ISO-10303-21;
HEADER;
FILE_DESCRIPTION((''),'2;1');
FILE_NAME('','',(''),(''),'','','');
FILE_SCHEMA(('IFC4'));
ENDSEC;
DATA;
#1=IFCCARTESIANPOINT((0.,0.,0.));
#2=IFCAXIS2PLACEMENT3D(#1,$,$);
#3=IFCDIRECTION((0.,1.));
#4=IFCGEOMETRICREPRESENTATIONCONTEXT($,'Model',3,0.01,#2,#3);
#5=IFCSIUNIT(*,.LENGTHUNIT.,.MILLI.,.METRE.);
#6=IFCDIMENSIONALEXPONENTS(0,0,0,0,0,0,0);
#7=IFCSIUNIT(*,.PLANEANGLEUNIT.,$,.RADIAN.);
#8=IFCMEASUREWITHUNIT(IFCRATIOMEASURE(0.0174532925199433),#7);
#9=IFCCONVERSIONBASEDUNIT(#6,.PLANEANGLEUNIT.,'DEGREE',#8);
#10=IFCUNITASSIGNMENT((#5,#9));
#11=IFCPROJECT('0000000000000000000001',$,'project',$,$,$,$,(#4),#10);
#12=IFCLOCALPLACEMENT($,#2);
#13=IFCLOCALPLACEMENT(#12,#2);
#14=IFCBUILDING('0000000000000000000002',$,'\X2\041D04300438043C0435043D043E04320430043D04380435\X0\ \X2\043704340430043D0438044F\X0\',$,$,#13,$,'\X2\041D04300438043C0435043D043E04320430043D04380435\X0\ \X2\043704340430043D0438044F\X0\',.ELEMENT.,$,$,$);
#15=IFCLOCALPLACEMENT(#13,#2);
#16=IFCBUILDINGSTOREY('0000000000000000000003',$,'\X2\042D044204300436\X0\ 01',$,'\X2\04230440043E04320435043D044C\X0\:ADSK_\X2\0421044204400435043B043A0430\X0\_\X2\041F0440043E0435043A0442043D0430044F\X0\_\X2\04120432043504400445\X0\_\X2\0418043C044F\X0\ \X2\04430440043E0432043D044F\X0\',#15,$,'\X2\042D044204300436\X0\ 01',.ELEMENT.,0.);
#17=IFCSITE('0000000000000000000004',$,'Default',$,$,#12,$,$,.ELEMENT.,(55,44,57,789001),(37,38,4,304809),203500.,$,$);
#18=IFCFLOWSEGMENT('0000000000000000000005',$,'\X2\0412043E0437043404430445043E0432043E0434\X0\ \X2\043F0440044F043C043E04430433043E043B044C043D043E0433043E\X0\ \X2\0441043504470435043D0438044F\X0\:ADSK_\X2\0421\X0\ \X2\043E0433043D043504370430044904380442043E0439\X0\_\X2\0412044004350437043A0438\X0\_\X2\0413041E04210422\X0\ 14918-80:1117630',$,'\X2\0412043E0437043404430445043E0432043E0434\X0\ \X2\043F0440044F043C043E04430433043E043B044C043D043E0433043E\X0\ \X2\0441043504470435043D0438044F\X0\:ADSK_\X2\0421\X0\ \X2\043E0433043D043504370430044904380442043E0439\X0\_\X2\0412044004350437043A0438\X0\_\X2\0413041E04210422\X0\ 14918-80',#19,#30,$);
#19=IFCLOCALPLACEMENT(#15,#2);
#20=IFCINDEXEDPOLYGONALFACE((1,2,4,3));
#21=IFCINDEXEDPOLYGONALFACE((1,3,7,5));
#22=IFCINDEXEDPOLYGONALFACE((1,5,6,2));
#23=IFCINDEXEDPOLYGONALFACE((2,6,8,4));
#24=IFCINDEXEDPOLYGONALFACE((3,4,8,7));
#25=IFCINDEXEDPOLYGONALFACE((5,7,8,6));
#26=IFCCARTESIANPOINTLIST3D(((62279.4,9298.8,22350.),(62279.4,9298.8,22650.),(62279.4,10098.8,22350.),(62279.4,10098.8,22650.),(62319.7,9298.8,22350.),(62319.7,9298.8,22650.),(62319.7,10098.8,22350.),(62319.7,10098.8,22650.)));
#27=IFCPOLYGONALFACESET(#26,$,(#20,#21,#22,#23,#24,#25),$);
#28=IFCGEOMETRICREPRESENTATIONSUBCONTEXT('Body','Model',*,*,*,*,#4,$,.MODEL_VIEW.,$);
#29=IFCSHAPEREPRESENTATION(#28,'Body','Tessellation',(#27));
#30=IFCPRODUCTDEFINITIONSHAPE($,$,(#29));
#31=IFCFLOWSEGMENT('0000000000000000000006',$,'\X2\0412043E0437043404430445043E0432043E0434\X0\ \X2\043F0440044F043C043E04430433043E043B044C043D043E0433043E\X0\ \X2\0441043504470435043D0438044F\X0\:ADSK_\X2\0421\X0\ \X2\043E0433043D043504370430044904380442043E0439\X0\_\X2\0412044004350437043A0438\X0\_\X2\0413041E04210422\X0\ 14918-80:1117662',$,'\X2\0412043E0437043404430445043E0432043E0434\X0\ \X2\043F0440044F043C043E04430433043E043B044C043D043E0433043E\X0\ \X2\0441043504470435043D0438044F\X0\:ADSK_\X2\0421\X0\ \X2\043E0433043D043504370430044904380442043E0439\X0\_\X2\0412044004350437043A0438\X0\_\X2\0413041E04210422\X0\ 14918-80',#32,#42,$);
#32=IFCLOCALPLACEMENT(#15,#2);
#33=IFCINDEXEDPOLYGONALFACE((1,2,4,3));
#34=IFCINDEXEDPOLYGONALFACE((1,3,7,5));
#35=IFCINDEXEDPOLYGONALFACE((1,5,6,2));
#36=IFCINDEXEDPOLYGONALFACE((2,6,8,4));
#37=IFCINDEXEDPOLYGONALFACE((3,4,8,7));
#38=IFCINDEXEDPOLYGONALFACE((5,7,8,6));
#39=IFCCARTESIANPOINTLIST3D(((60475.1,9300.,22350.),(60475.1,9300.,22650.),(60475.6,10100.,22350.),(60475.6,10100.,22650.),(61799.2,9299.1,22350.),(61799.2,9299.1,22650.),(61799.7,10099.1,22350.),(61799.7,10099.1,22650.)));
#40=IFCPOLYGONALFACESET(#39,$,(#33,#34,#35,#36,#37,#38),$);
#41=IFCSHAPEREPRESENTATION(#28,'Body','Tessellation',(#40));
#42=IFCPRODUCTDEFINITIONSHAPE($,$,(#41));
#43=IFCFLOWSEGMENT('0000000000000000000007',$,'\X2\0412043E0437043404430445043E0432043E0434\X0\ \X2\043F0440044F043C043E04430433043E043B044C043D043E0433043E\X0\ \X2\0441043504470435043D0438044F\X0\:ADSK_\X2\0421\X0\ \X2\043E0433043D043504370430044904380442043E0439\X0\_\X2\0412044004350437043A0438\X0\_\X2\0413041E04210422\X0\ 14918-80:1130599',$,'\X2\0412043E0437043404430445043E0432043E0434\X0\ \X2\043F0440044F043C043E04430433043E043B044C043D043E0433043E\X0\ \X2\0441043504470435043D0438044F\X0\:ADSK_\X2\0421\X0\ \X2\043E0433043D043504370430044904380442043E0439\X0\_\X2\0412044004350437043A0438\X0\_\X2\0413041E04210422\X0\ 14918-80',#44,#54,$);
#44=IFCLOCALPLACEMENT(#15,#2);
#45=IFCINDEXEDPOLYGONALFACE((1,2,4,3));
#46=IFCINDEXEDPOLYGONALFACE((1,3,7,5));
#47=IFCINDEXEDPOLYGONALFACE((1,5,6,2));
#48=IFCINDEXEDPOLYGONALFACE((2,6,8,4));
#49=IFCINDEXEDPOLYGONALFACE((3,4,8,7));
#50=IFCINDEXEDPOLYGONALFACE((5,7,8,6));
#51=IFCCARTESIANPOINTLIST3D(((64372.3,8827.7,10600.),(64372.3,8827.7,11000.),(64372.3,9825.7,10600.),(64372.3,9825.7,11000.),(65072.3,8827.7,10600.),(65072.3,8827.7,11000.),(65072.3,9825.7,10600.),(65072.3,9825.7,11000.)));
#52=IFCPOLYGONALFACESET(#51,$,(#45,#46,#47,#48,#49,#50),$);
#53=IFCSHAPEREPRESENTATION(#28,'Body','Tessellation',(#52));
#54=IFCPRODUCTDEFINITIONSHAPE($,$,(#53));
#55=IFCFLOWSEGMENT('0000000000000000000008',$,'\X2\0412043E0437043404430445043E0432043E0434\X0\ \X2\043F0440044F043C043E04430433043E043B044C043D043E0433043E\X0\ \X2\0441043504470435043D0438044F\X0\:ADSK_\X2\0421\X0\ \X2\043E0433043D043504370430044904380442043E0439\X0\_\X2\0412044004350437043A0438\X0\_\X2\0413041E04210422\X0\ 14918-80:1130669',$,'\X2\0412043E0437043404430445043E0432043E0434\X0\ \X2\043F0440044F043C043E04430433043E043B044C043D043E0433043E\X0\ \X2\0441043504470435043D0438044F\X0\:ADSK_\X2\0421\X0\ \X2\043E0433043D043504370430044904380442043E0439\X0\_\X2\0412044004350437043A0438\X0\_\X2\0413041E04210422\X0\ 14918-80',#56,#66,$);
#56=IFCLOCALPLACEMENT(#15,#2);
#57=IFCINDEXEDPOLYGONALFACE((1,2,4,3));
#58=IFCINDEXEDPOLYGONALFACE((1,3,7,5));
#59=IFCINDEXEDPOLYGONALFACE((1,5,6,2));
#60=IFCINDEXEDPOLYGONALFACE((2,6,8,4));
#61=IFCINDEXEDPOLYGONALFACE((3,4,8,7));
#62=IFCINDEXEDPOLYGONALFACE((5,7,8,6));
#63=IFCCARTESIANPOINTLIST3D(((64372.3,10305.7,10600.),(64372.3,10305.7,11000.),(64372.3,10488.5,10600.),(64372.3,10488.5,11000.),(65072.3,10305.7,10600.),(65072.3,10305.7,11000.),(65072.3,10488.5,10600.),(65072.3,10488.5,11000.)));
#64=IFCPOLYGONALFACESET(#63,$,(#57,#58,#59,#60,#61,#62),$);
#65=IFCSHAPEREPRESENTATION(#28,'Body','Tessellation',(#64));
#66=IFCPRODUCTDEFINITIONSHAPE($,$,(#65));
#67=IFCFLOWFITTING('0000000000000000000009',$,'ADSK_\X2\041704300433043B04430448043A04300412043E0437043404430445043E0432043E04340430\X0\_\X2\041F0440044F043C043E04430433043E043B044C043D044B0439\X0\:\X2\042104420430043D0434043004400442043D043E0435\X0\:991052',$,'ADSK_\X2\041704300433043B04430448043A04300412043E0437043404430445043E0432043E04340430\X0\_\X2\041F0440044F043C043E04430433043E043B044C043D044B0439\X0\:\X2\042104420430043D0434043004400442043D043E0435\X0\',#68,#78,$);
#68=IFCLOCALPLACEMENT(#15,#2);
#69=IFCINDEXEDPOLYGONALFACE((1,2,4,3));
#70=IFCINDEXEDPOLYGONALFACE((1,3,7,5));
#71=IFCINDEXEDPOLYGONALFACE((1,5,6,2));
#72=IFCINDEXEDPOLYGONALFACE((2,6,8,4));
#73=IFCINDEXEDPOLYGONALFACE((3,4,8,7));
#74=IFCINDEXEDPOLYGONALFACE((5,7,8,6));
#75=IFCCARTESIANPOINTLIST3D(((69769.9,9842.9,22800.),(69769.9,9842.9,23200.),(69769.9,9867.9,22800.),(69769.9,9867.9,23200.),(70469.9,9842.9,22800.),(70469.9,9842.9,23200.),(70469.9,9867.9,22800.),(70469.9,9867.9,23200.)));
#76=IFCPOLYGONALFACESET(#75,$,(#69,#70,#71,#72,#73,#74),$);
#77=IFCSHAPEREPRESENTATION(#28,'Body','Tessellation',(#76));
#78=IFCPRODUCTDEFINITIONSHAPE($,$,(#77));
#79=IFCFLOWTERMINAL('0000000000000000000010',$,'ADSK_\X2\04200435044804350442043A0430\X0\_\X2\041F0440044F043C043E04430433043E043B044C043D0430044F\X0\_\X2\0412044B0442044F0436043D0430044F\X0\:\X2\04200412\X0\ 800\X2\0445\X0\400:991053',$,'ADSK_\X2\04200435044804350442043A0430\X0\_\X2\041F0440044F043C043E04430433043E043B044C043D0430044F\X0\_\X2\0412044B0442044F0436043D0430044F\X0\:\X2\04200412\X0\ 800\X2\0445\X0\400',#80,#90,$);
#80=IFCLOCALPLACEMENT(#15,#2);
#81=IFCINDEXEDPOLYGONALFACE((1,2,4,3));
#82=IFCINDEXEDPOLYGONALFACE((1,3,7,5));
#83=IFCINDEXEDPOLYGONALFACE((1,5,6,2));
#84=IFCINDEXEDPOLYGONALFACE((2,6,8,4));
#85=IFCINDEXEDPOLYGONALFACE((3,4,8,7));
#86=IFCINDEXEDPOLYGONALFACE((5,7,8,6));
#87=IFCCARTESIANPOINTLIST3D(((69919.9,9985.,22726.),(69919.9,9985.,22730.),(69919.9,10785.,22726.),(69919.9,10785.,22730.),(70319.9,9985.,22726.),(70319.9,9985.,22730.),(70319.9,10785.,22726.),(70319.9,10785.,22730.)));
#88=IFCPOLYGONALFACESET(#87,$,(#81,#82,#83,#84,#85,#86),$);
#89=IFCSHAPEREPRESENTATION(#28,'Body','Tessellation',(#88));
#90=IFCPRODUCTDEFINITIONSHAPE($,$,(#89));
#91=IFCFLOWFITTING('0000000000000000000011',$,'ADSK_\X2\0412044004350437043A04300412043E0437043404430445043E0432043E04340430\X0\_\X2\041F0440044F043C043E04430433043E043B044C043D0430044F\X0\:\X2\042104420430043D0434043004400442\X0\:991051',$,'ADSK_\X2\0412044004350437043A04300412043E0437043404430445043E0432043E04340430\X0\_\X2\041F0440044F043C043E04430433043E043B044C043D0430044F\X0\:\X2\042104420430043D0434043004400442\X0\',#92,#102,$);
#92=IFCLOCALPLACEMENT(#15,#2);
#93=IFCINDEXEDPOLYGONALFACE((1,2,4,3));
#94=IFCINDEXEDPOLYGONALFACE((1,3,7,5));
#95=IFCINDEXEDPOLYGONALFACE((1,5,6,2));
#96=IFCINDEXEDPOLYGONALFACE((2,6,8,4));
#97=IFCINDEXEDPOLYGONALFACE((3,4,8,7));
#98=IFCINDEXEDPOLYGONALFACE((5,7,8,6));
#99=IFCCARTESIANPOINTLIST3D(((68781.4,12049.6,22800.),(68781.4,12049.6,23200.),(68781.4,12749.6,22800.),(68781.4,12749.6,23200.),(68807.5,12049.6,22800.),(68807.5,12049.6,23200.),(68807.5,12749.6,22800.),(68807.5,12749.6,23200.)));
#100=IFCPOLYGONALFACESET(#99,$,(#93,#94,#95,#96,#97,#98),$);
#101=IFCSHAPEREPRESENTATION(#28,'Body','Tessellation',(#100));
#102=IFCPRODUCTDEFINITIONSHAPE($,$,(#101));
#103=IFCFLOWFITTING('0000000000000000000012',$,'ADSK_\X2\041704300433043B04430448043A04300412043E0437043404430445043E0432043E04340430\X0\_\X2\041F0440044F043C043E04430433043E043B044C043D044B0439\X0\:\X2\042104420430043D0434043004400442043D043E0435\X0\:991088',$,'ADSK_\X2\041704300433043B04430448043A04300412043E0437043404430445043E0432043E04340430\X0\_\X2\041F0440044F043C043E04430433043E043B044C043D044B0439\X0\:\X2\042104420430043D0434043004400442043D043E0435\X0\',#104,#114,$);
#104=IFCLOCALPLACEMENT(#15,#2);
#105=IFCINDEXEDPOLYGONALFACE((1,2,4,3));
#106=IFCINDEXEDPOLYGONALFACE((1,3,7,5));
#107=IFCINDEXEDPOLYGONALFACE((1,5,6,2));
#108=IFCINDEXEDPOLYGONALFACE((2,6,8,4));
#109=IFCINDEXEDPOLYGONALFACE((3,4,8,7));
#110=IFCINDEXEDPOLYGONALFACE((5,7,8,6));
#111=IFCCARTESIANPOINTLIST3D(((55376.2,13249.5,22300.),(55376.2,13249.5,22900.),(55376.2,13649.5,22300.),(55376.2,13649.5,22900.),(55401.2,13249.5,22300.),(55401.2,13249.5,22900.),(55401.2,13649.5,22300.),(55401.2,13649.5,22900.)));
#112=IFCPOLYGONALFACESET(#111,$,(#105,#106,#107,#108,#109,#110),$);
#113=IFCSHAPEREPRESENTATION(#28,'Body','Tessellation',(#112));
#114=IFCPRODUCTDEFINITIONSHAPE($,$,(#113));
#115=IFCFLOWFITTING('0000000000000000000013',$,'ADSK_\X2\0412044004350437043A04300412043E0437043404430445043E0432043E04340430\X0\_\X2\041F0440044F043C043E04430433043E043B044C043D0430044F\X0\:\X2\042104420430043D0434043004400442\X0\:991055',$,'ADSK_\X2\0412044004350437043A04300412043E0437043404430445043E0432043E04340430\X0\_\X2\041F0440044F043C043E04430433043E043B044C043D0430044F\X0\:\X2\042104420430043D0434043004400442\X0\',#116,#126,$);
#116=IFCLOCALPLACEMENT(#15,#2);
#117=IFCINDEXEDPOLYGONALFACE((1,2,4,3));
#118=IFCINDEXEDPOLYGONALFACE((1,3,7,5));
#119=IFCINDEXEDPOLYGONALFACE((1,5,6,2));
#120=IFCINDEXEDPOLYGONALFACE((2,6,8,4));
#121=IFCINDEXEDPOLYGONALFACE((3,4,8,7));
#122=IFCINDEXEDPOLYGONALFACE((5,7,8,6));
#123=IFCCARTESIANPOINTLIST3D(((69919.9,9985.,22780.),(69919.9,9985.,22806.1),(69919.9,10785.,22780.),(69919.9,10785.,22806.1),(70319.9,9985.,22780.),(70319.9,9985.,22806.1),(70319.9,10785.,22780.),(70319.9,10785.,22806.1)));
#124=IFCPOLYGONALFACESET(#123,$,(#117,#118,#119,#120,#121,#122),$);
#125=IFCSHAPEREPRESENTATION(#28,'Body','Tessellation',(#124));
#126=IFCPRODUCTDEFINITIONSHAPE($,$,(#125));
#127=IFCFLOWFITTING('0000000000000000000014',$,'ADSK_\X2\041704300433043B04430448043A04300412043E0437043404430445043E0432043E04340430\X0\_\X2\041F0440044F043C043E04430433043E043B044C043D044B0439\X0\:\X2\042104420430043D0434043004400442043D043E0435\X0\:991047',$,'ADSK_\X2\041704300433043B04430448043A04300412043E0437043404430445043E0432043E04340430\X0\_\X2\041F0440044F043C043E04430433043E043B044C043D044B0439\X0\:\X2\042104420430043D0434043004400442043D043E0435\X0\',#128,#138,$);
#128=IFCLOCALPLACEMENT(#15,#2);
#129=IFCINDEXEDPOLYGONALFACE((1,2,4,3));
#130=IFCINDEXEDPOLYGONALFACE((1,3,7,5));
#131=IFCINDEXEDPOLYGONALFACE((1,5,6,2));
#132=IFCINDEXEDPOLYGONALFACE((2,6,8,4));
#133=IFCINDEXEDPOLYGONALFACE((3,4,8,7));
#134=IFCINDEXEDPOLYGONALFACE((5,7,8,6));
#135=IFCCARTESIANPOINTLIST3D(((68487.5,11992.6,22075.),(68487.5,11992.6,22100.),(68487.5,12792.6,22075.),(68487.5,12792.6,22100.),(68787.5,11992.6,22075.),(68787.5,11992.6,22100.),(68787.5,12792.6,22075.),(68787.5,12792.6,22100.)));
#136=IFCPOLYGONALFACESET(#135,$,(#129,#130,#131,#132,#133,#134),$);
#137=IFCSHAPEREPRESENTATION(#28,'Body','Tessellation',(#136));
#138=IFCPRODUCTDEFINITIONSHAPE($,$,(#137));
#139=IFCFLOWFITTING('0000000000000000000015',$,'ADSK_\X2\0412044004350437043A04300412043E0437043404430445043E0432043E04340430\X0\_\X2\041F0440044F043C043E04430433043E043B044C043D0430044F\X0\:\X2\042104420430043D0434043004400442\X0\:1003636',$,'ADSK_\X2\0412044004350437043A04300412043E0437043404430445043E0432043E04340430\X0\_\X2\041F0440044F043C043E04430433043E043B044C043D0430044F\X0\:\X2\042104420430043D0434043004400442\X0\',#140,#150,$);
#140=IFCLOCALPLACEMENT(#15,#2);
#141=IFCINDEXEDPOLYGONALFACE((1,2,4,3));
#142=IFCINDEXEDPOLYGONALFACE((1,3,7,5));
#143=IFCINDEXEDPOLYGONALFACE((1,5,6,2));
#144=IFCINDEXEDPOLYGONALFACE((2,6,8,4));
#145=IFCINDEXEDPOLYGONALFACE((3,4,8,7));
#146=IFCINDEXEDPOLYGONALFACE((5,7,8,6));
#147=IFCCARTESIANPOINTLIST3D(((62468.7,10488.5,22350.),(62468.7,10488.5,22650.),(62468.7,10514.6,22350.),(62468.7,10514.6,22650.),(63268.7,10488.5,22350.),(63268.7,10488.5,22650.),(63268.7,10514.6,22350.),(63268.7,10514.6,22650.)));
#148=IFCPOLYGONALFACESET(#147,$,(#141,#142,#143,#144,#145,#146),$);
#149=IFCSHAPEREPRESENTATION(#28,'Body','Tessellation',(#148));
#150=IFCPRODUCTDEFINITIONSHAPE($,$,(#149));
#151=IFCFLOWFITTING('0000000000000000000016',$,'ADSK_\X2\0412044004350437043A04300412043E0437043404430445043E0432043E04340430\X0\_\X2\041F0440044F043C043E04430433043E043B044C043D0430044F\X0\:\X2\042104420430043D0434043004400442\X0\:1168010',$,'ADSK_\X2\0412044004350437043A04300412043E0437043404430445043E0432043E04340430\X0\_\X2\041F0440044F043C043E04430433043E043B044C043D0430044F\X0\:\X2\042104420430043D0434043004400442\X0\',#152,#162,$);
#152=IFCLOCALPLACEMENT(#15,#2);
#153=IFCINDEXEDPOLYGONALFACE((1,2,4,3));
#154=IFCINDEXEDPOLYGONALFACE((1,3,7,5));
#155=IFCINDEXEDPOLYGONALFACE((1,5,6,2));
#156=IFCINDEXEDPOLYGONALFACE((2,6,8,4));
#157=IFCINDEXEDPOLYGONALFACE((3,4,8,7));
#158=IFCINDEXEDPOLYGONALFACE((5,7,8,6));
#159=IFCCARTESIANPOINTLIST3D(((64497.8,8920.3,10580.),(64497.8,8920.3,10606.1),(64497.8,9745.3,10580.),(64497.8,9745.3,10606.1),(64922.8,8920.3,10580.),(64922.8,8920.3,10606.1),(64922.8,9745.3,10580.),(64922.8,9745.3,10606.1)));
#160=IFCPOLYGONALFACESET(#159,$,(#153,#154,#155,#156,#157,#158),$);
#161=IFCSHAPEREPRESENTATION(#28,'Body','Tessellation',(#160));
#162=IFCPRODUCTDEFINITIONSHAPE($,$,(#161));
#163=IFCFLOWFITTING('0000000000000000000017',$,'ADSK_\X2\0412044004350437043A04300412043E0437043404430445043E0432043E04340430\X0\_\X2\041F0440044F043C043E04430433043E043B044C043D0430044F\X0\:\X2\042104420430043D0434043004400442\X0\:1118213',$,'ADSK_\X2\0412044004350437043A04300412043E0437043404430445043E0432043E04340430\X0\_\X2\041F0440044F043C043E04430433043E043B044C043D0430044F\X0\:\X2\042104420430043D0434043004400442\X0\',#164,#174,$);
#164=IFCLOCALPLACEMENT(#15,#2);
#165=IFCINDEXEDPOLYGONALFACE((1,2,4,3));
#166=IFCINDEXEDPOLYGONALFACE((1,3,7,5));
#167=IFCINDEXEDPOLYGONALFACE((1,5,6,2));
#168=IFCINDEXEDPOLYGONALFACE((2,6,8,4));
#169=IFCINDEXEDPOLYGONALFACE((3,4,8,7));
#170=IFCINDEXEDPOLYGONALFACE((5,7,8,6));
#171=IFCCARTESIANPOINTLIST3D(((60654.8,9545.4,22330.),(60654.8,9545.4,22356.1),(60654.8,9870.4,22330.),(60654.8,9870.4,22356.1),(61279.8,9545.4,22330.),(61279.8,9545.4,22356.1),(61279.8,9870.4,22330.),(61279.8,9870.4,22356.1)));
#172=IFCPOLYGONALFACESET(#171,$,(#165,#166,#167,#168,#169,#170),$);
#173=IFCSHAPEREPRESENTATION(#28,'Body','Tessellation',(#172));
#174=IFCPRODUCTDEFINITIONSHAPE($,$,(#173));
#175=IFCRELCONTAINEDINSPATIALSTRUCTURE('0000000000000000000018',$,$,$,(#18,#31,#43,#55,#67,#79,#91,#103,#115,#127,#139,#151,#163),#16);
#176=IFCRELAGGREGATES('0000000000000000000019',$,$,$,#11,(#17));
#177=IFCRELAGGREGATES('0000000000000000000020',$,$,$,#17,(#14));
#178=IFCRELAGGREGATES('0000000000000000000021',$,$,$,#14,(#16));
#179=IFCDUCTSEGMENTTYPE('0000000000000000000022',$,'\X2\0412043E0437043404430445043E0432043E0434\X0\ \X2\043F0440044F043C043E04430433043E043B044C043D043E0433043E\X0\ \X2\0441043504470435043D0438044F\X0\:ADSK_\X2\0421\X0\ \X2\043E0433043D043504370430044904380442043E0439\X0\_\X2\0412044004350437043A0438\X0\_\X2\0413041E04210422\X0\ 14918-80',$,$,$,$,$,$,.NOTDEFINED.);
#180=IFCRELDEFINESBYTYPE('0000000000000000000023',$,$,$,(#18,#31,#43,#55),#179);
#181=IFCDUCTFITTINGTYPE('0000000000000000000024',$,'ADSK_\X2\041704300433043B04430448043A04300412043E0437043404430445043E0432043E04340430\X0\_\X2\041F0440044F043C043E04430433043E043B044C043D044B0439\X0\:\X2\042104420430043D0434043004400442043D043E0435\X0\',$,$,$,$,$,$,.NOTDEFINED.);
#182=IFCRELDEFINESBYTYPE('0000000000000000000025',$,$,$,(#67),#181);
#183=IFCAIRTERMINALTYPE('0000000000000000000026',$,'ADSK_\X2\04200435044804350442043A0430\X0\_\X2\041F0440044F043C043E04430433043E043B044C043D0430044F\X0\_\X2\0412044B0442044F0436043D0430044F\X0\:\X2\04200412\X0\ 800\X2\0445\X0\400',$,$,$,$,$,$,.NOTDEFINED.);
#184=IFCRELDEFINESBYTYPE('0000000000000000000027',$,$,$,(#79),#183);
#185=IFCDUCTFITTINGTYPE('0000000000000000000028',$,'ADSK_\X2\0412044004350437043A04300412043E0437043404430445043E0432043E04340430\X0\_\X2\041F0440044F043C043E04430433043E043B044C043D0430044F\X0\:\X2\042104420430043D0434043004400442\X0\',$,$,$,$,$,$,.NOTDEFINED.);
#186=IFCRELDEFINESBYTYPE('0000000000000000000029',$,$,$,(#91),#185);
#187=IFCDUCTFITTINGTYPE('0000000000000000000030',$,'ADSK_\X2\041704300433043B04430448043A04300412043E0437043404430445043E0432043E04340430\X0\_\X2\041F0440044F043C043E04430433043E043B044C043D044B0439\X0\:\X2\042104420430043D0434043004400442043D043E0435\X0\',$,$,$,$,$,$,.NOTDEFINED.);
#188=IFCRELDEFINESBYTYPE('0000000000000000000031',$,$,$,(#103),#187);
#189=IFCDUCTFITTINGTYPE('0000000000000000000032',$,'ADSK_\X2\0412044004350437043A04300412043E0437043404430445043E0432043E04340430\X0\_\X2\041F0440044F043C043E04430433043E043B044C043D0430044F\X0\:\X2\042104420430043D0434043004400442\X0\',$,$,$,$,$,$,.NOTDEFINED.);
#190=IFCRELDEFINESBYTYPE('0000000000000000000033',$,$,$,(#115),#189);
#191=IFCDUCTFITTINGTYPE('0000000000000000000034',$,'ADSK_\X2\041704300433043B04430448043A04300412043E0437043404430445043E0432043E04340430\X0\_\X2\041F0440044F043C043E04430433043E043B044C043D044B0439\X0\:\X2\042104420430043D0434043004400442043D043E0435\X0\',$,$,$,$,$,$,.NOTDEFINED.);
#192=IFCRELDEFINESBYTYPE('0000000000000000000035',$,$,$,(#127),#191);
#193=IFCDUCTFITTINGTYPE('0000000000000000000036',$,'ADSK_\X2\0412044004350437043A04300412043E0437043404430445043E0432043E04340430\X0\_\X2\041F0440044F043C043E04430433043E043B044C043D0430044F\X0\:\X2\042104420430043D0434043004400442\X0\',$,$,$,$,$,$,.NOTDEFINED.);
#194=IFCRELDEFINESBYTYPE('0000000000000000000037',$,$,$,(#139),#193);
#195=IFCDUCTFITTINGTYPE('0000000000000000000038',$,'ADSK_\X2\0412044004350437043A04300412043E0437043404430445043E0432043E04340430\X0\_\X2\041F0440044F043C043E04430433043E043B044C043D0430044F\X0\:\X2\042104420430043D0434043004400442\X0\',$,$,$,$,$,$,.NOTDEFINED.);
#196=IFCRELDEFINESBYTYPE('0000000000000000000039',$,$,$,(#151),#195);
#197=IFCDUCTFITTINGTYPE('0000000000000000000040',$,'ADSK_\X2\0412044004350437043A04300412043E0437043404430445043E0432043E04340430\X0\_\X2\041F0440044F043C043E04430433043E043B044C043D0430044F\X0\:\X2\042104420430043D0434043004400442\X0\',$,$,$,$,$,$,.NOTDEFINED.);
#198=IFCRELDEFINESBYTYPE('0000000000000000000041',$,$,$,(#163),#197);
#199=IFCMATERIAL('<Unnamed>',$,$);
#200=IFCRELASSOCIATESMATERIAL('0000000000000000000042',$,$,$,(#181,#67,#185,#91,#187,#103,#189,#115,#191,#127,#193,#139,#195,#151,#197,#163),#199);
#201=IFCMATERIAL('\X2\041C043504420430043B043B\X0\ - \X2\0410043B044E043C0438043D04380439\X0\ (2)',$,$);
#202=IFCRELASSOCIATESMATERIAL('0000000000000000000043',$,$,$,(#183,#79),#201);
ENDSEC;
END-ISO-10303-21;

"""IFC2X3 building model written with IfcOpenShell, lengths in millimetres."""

from ifc_helpers import new_model, entity, si_unit, converted_unit, direction, frame, frame_2d, origin, origin_2d_with_axis, place, context, subcontext, project, spatial, rectangle, extrude, source, transform, mapped, material, type_object, type_shapes, element, save


model = new_model("IFC2X3")

# Units and contexts
model_context = context("Model", 3, precision=0.01, world=origin(), true_north=direction((0.0, 1.0)))
body_context = subcontext(model_context, "Body", "Model", "MODEL_VIEW")
ifc_project = project(units=[si_unit("LENGTHUNIT", "METRE", prefix="MILLI"), converted_unit("PLANEANGLEUNIT", "DEGREE", entity("IfcRatioMeasure", 0.0174532925199433), si_unit("PLANEANGLEUNIT", "RADIAN"), dimensions=[0, 0, 0, 0, 0, 0, 0])], contexts=[model_context])

# Site, building, storey
site_placement = place(None, frame((0.0, 0.0, 0.0)))
site = spatial("IfcSite", under=ifc_project, at=site_placement, Name="Default", CompositionType="ELEMENT", RefLatitude=(55, 44, 57, 789001), RefLongitude=(37, 38, 4, 304809), RefElevation=203500.0)
building_placement = place(site_placement, origin())
building = spatial("IfcBuilding", under=site, at=building_placement, Name="Наименование здания", LongName="Наименование здания", CompositionType="ELEMENT")
storey_placement = place(building_placement, origin())
storey = spatial("IfcBuildingStorey", under=building, at=storey_placement, Name="Этаж 01", ObjectType="Уровень:ADSK_Стрелка_Проектная_Вверх_Имя уровня", LongName="Этаж 01", CompositionType="ELEMENT", Elevation=0.0)

# Flow segments
duct_segment_type = type_object("IfcDuctSegmentType", Name="Воздуховод прямоугольного сечения:ADSK_С огнезащитой_Врезки_ГОСТ 14918-80", PredefinedType="NOTDEFINED")
flow_segment_1_placement = place(storey_placement, frame((62279.4, 9298.8, 22350.0)))
element("IfcFlowSegment", 1, at=flow_segment_1_placement, inside=storey, type_object=duct_segment_type, Name="Воздуховод прямоугольного сечения:ADSK_С огнезащитой_Врезки_ГОСТ 14918-80:1117630", ObjectType="Воздуховод прямоугольного сечения:ADSK_С огнезащитой_Врезки_ГОСТ 14918-80", context=body_context, shape_type="SweptSolid", body=[
    extrude(rectangle(XDim=40.3, YDim=800.0, at=frame_2d((0.0, 0.0), x_axis=(1.0, 0.0))), frame((20.1, 400.0, 0.0), z_axis=(0.0, 0.0, 1.0), x_axis=(-1.0, 0.0, 0.0)), (0.0, 0.0, 1.0), 300.0),
])
flow_segment_2_placement = place(storey_placement, frame((60475.1, 9299.1, 22350.0)))
element("IfcFlowSegment", 2, at=flow_segment_2_placement, inside=storey, type_object=duct_segment_type, Name="Воздуховод прямоугольного сечения:ADSK_С огнезащитой_Врезки_ГОСТ 14918-80:1117662", ObjectType="Воздуховод прямоугольного сечения:ADSK_С огнезащитой_Врезки_ГОСТ 14918-80", context=body_context, shape_type="SweptSolid", body=[
    extrude(rectangle(XDim=1324.1, YDim=800.0, at=frame_2d((0.0, 0.0), x_axis=(1.0, 0.0))), frame((662.3, 400.4, 0.0), z_axis=(0.0, 0.0, 1.0), x_axis=(-1.0, 0.000623, 0.0)), (0.0, 0.0, 1.0), 300.0),
])
flow_segment_3_placement = place(storey_placement, frame((64372.3, 8827.7, 10600.0)))
element("IfcFlowSegment", 3, at=flow_segment_3_placement, inside=storey, type_object=duct_segment_type, Name="Воздуховод прямоугольного сечения:ADSK_С огнезащитой_Врезки_ГОСТ 14918-80:1130599", ObjectType="Воздуховод прямоугольного сечения:ADSK_С огнезащитой_Врезки_ГОСТ 14918-80", context=body_context, shape_type="SweptSolid", body=[
    extrude(rectangle(XDim=998.0, YDim=700.0, at=frame_2d((0.0, 0.0), x_axis=(1.0, 0.0))), frame((350.0, 499.0, 0.0), z_axis=(0.0, 0.0, 1.0), x_axis=(0.0, -1.0, 0.0)), (0.0, 0.0, 1.0), 400.0),
])
flow_segment_4_placement = place(storey_placement, frame((64372.3, 10305.7, 10600.0)))
element("IfcFlowSegment", 4, at=flow_segment_4_placement, inside=storey, type_object=duct_segment_type, Name="Воздуховод прямоугольного сечения:ADSK_С огнезащитой_Врезки_ГОСТ 14918-80:1130669", ObjectType="Воздуховод прямоугольного сечения:ADSK_С огнезащитой_Врезки_ГОСТ 14918-80", context=body_context, shape_type="SweptSolid", body=[
    extrude(rectangle(XDim=182.8, YDim=700.0, at=frame_2d((0.0, 0.0), x_axis=(1.0, 0.0))), frame((350.0, 91.4, 0.0), z_axis=(0.0, 0.0, 1.0), x_axis=(0.0, 1.0, 0.0)), (0.0, 0.0, 1.0), 400.0),
])

# Flow fitting
ifc_material_1 = material(Name="<Unnamed>")
duct_fitting_type_1 = type_object("IfcDuctFittingType", Name="ADSK_ЗаглушкаВоздуховода_Прямоугольный:Стандартное", PredefinedType="NOTDEFINED", material=ifc_material_1)
shared_shape_1 = source(origin(), body_context, "Body", "SweptSolid", [
    extrude(rectangle(XDim=25.0, YDim=700.0, at=frame_2d((0.0, 0.0), x_axis=(1.0, 0.0))), frame((12.5, 0.0, -200.0)), (0.0, 0.0, 1.0), 400.0),
])
type_shapes(duct_fitting_type_1, [shared_shape_1])
flow_fitting_1_placement = place(storey_placement, frame((70119.9, 9867.9, 23000.0), z_axis=(0.0, 0.0, 1.0), x_axis=(0.0, -1.0, 0.0)))
element("IfcFlowFitting", 5, at=flow_fitting_1_placement, inside=storey, type_object=duct_fitting_type_1, material=ifc_material_1, Name="ADSK_ЗаглушкаВоздуховода_Прямоугольный:Стандартное:991052", ObjectType="ADSK_ЗаглушкаВоздуховода_Прямоугольный:Стандартное", context=body_context, shape_type="MappedRepresentation", body=[
    mapped(shared_shape_1, transform((0.0, 0.0, 0.0), scale=1.0)),
])

# Flow terminal
ifc_material_2 = material(Name="Металл - Алюминий (2)")
air_terminal_type = type_object("IfcAirTerminalType", Name="ADSK_Решетка_Прямоугольная_Вытяжная:РВ 800х400", PredefinedType="NOTDEFINED", material=ifc_material_2)
shared_shape_2 = source(origin(), body_context, "Body", "SweptSolid", [
    extrude(rectangle(XDim=4.0, YDim=800.0, at=origin_2d_with_axis()), frame((0.0, -2.0, -200.0), z_axis=(0.0, 0.0, 1.0), x_axis=(0.0, 1.0, 0.0)), (0.0, 0.0, 1.0), 400.0),
])
type_shapes(air_terminal_type, [shared_shape_2])
flow_terminal_placement = place(storey_placement, frame((70119.9, 10385.0, 22730.0), z_axis=(1.0, 0.0, 0.0), x_axis=(0.0, 1.0, 0.0)))
element("IfcFlowTerminal", 6, at=flow_terminal_placement, inside=storey, type_object=air_terminal_type, material=ifc_material_2, Name="ADSK_Решетка_Прямоугольная_Вытяжная:РВ 800х400:991053", ObjectType="ADSK_Решетка_Прямоугольная_Вытяжная:РВ 800х400", context=body_context, shape_type="MappedRepresentation", body=[
    mapped(shared_shape_2, transform((0.0, 0.0, 0.0), scale=1.0)),
])

# Flow fittings
duct_fitting_type_2 = type_object("IfcDuctFittingType", Name="ADSK_ВрезкаВоздуховода_Прямоугольная:Стандарт", PredefinedType="NOTDEFINED", material=ifc_material_1)
shared_shape_3 = source(origin(), body_context, "Body", "SweptSolid", [
    extrude(rectangle(XDim=26.1, YDim=400.0, at=frame_2d((0.0, 0.0), x_axis=(1.0, 0.0))), frame((7.0, 0.0, -350.0)), (0.0, 0.0, 1.0), 700.0),
])
type_shapes(duct_fitting_type_2, [shared_shape_3])
flow_fitting_2_placement = place(storey_placement, frame((68787.5, 12399.6, 23000.0), z_axis=(0.0, -1.0, 0.0), x_axis=(1.0, 0.0, 0.0)))
element("IfcFlowFitting", 7, at=flow_fitting_2_placement, inside=storey, type_object=duct_fitting_type_2, material=ifc_material_1, Name="ADSK_ВрезкаВоздуховода_Прямоугольная:Стандарт:991051", ObjectType="ADSK_ВрезкаВоздуховода_Прямоугольная:Стандарт", context=body_context, shape_type="MappedRepresentation", body=[
    mapped(shared_shape_3, transform((0.0, 0.0, 0.0), scale=1.0)),
])
duct_fitting_type_3 = type_object("IfcDuctFittingType", Name="ADSK_ЗаглушкаВоздуховода_Прямоугольный:Стандартное", PredefinedType="NOTDEFINED", material=ifc_material_1)
shared_shape_4 = source(origin(), body_context, "Body", "SweptSolid", [
    extrude(rectangle(XDim=25.0, YDim=400.0, at=frame_2d((0.0, 0.0), x_axis=(1.0, 0.0))), frame((12.5, 0.0, -300.0)), (0.0, 0.0, 1.0), 600.0),
])
type_shapes(duct_fitting_type_3, [shared_shape_4])
flow_fitting_3_placement = place(storey_placement, frame((55376.2, 13449.5, 22600.0)))
element("IfcFlowFitting", 8, at=flow_fitting_3_placement, inside=storey, type_object=duct_fitting_type_3, material=ifc_material_1, Name="ADSK_ЗаглушкаВоздуховода_Прямоугольный:Стандартное:991088", ObjectType="ADSK_ЗаглушкаВоздуховода_Прямоугольный:Стандартное", context=body_context, shape_type="MappedRepresentation", body=[
    mapped(shared_shape_4, transform((0.0, 0.0, 0.0), scale=1.0)),
])
duct_fitting_type_4 = type_object("IfcDuctFittingType", Name="ADSK_ВрезкаВоздуховода_Прямоугольная:Стандарт", PredefinedType="NOTDEFINED", material=ifc_material_1)
shared_shape_5 = source(origin(), body_context, "Body", "SweptSolid", [
    extrude(rectangle(XDim=400.0, YDim=26.1, at=origin_2d_with_axis()), frame((7.0, 0.0, -400.0), z_axis=(0.0, 0.0, 1.0), x_axis=(0.0, -1.0, 0.0)), (0.0, 0.0, 1.0), 800.0),
])
type_shapes(duct_fitting_type_4, [shared_shape_5])
flow_fitting_4_placement = place(storey_placement, frame((70119.9, 10385.0, 22800.0), z_axis=(0.0, -1.0, 0.0), x_axis=(0.0, 0.0, -1.0)))
element("IfcFlowFitting", 9, at=flow_fitting_4_placement, inside=storey, type_object=duct_fitting_type_4, material=ifc_material_1, Name="ADSK_ВрезкаВоздуховода_Прямоугольная:Стандарт:991055", ObjectType="ADSK_ВрезкаВоздуховода_Прямоугольная:Стандарт", context=body_context, shape_type="MappedRepresentation", body=[
    mapped(shared_shape_5, transform((0.0, 0.0, 0.0), scale=1.0)),
])
duct_fitting_type_5 = type_object("IfcDuctFittingType", Name="ADSK_ЗаглушкаВоздуховода_Прямоугольный:Стандартное", PredefinedType="NOTDEFINED", material=ifc_material_1)
shared_shape_6 = source(origin(), body_context, "Body", "SweptSolid", [
    extrude(rectangle(XDim=25.0, YDim=300.0, at=frame_2d((0.0, 0.0), x_axis=(1.0, 0.0))), frame((12.5, 0.0, -400.0)), (0.0, 0.0, 1.0), 800.0),
])
type_shapes(duct_fitting_type_5, [shared_shape_6])
flow_fitting_5_placement = place(storey_placement, frame((68637.5, 12392.6, 22100.0), z_axis=(0.0, -1.0, 0.0), x_axis=(0.0, 0.0, -1.0)))
element("IfcFlowFitting", 10, at=flow_fitting_5_placement, inside=storey, type_object=duct_fitting_type_5, material=ifc_material_1, Name="ADSK_ЗаглушкаВоздуховода_Прямоугольный:Стандартное:991047", ObjectType="ADSK_ЗаглушкаВоздуховода_Прямоугольный:Стандартное", context=body_context, shape_type="MappedRepresentation", body=[
    mapped(shared_shape_6, transform((0.0, 0.0, 0.0), scale=1.0)),
])
duct_fitting_type_6 = type_object("IfcDuctFittingType", Name="ADSK_ВрезкаВоздуховода_Прямоугольная:Стандарт", PredefinedType="NOTDEFINED", material=ifc_material_1)
shared_shape_7 = source(origin(), body_context, "Body", "SweptSolid", [
    extrude(rectangle(XDim=26.1, YDim=300.0, at=frame_2d((0.0, 0.0), x_axis=(1.0, 0.0))), frame((7.0, 0.0, -400.0)), (0.0, 0.0, 1.0), 800.0),
])
type_shapes(duct_fitting_type_6, [shared_shape_7])
flow_fitting_6_placement = place(storey_placement, frame((62868.7, 10508.5, 22500.0), z_axis=(-1.0, 0.0, 0.0), x_axis=(0.0, -1.0, 0.0)))
element("IfcFlowFitting", 11, at=flow_fitting_6_placement, inside=storey, type_object=duct_fitting_type_6, material=ifc_material_1, Name="ADSK_ВрезкаВоздуховода_Прямоугольная:Стандарт:1003636", ObjectType="ADSK_ВрезкаВоздуховода_Прямоугольная:Стандарт", context=body_context, shape_type="MappedRepresentation", body=[
    mapped(shared_shape_7, transform((0.0, 0.0, 0.0), scale=1.0)),
])
duct_fitting_type_7 = type_object("IfcDuctFittingType", Name="ADSK_ВрезкаВоздуховода_Прямоугольная:Стандарт", PredefinedType="NOTDEFINED", material=ifc_material_1)
shared_shape_8 = source(origin(), body_context, "Body", "SweptSolid", [
    extrude(rectangle(XDim=425.0, YDim=26.1, at=origin_2d_with_axis()), frame((7.0, 0.0, -412.5), z_axis=(0.0, 0.0, 1.0), x_axis=(0.0, -1.0, 0.0)), (0.0, 0.0, 1.0), 825.0),
])
type_shapes(duct_fitting_type_7, [shared_shape_8])
flow_fitting_7_placement = place(storey_placement, frame((64710.3, 9332.8, 10600.0), z_axis=(0.0, 1.0, 0.0), x_axis=(0.0, 0.0, -1.0)))
element("IfcFlowFitting", 12, at=flow_fitting_7_placement, inside=storey, type_object=duct_fitting_type_7, material=ifc_material_1, Name="ADSK_ВрезкаВоздуховода_Прямоугольная:Стандарт:1168010", ObjectType="ADSK_ВрезкаВоздуховода_Прямоугольная:Стандарт", context=body_context, shape_type="MappedRepresentation", body=[
    mapped(shared_shape_8, transform((0.0, 0.0, 0.0), scale=1.0)),
])
duct_fitting_type_8 = type_object("IfcDuctFittingType", Name="ADSK_ВрезкаВоздуховода_Прямоугольная:Стандарт", PredefinedType="NOTDEFINED", material=ifc_material_1)
shared_shape_9 = source(origin(), body_context, "Body", "SweptSolid", [
    extrude(rectangle(XDim=26.1, YDim=625.0, at=frame_2d((0.0, 0.0), x_axis=(1.0, 0.0))), frame((7.0, 0.0, -162.5)), (0.0, 0.0, 1.0), 325.0),
])
type_shapes(duct_fitting_type_8, [shared_shape_9])
flow_fitting_8_placement = place(storey_placement, frame((60967.3, 9707.9, 22350.0), z_axis=(0.0, -1.0, 0.0), x_axis=(0.0, 0.0, -1.0)))
element("IfcFlowFitting", 13, at=flow_fitting_8_placement, inside=storey, type_object=duct_fitting_type_8, material=ifc_material_1, Name="ADSK_ВрезкаВоздуховода_Прямоугольная:Стандарт:1118213", ObjectType="ADSK_ВрезкаВоздуховода_Прямоугольная:Стандарт", context=body_context, shape_type="MappedRepresentation", body=[
    mapped(shared_shape_9, transform((0.0, 0.0, 0.0), scale=1.0)),
])

save(model, "model.ifc")
